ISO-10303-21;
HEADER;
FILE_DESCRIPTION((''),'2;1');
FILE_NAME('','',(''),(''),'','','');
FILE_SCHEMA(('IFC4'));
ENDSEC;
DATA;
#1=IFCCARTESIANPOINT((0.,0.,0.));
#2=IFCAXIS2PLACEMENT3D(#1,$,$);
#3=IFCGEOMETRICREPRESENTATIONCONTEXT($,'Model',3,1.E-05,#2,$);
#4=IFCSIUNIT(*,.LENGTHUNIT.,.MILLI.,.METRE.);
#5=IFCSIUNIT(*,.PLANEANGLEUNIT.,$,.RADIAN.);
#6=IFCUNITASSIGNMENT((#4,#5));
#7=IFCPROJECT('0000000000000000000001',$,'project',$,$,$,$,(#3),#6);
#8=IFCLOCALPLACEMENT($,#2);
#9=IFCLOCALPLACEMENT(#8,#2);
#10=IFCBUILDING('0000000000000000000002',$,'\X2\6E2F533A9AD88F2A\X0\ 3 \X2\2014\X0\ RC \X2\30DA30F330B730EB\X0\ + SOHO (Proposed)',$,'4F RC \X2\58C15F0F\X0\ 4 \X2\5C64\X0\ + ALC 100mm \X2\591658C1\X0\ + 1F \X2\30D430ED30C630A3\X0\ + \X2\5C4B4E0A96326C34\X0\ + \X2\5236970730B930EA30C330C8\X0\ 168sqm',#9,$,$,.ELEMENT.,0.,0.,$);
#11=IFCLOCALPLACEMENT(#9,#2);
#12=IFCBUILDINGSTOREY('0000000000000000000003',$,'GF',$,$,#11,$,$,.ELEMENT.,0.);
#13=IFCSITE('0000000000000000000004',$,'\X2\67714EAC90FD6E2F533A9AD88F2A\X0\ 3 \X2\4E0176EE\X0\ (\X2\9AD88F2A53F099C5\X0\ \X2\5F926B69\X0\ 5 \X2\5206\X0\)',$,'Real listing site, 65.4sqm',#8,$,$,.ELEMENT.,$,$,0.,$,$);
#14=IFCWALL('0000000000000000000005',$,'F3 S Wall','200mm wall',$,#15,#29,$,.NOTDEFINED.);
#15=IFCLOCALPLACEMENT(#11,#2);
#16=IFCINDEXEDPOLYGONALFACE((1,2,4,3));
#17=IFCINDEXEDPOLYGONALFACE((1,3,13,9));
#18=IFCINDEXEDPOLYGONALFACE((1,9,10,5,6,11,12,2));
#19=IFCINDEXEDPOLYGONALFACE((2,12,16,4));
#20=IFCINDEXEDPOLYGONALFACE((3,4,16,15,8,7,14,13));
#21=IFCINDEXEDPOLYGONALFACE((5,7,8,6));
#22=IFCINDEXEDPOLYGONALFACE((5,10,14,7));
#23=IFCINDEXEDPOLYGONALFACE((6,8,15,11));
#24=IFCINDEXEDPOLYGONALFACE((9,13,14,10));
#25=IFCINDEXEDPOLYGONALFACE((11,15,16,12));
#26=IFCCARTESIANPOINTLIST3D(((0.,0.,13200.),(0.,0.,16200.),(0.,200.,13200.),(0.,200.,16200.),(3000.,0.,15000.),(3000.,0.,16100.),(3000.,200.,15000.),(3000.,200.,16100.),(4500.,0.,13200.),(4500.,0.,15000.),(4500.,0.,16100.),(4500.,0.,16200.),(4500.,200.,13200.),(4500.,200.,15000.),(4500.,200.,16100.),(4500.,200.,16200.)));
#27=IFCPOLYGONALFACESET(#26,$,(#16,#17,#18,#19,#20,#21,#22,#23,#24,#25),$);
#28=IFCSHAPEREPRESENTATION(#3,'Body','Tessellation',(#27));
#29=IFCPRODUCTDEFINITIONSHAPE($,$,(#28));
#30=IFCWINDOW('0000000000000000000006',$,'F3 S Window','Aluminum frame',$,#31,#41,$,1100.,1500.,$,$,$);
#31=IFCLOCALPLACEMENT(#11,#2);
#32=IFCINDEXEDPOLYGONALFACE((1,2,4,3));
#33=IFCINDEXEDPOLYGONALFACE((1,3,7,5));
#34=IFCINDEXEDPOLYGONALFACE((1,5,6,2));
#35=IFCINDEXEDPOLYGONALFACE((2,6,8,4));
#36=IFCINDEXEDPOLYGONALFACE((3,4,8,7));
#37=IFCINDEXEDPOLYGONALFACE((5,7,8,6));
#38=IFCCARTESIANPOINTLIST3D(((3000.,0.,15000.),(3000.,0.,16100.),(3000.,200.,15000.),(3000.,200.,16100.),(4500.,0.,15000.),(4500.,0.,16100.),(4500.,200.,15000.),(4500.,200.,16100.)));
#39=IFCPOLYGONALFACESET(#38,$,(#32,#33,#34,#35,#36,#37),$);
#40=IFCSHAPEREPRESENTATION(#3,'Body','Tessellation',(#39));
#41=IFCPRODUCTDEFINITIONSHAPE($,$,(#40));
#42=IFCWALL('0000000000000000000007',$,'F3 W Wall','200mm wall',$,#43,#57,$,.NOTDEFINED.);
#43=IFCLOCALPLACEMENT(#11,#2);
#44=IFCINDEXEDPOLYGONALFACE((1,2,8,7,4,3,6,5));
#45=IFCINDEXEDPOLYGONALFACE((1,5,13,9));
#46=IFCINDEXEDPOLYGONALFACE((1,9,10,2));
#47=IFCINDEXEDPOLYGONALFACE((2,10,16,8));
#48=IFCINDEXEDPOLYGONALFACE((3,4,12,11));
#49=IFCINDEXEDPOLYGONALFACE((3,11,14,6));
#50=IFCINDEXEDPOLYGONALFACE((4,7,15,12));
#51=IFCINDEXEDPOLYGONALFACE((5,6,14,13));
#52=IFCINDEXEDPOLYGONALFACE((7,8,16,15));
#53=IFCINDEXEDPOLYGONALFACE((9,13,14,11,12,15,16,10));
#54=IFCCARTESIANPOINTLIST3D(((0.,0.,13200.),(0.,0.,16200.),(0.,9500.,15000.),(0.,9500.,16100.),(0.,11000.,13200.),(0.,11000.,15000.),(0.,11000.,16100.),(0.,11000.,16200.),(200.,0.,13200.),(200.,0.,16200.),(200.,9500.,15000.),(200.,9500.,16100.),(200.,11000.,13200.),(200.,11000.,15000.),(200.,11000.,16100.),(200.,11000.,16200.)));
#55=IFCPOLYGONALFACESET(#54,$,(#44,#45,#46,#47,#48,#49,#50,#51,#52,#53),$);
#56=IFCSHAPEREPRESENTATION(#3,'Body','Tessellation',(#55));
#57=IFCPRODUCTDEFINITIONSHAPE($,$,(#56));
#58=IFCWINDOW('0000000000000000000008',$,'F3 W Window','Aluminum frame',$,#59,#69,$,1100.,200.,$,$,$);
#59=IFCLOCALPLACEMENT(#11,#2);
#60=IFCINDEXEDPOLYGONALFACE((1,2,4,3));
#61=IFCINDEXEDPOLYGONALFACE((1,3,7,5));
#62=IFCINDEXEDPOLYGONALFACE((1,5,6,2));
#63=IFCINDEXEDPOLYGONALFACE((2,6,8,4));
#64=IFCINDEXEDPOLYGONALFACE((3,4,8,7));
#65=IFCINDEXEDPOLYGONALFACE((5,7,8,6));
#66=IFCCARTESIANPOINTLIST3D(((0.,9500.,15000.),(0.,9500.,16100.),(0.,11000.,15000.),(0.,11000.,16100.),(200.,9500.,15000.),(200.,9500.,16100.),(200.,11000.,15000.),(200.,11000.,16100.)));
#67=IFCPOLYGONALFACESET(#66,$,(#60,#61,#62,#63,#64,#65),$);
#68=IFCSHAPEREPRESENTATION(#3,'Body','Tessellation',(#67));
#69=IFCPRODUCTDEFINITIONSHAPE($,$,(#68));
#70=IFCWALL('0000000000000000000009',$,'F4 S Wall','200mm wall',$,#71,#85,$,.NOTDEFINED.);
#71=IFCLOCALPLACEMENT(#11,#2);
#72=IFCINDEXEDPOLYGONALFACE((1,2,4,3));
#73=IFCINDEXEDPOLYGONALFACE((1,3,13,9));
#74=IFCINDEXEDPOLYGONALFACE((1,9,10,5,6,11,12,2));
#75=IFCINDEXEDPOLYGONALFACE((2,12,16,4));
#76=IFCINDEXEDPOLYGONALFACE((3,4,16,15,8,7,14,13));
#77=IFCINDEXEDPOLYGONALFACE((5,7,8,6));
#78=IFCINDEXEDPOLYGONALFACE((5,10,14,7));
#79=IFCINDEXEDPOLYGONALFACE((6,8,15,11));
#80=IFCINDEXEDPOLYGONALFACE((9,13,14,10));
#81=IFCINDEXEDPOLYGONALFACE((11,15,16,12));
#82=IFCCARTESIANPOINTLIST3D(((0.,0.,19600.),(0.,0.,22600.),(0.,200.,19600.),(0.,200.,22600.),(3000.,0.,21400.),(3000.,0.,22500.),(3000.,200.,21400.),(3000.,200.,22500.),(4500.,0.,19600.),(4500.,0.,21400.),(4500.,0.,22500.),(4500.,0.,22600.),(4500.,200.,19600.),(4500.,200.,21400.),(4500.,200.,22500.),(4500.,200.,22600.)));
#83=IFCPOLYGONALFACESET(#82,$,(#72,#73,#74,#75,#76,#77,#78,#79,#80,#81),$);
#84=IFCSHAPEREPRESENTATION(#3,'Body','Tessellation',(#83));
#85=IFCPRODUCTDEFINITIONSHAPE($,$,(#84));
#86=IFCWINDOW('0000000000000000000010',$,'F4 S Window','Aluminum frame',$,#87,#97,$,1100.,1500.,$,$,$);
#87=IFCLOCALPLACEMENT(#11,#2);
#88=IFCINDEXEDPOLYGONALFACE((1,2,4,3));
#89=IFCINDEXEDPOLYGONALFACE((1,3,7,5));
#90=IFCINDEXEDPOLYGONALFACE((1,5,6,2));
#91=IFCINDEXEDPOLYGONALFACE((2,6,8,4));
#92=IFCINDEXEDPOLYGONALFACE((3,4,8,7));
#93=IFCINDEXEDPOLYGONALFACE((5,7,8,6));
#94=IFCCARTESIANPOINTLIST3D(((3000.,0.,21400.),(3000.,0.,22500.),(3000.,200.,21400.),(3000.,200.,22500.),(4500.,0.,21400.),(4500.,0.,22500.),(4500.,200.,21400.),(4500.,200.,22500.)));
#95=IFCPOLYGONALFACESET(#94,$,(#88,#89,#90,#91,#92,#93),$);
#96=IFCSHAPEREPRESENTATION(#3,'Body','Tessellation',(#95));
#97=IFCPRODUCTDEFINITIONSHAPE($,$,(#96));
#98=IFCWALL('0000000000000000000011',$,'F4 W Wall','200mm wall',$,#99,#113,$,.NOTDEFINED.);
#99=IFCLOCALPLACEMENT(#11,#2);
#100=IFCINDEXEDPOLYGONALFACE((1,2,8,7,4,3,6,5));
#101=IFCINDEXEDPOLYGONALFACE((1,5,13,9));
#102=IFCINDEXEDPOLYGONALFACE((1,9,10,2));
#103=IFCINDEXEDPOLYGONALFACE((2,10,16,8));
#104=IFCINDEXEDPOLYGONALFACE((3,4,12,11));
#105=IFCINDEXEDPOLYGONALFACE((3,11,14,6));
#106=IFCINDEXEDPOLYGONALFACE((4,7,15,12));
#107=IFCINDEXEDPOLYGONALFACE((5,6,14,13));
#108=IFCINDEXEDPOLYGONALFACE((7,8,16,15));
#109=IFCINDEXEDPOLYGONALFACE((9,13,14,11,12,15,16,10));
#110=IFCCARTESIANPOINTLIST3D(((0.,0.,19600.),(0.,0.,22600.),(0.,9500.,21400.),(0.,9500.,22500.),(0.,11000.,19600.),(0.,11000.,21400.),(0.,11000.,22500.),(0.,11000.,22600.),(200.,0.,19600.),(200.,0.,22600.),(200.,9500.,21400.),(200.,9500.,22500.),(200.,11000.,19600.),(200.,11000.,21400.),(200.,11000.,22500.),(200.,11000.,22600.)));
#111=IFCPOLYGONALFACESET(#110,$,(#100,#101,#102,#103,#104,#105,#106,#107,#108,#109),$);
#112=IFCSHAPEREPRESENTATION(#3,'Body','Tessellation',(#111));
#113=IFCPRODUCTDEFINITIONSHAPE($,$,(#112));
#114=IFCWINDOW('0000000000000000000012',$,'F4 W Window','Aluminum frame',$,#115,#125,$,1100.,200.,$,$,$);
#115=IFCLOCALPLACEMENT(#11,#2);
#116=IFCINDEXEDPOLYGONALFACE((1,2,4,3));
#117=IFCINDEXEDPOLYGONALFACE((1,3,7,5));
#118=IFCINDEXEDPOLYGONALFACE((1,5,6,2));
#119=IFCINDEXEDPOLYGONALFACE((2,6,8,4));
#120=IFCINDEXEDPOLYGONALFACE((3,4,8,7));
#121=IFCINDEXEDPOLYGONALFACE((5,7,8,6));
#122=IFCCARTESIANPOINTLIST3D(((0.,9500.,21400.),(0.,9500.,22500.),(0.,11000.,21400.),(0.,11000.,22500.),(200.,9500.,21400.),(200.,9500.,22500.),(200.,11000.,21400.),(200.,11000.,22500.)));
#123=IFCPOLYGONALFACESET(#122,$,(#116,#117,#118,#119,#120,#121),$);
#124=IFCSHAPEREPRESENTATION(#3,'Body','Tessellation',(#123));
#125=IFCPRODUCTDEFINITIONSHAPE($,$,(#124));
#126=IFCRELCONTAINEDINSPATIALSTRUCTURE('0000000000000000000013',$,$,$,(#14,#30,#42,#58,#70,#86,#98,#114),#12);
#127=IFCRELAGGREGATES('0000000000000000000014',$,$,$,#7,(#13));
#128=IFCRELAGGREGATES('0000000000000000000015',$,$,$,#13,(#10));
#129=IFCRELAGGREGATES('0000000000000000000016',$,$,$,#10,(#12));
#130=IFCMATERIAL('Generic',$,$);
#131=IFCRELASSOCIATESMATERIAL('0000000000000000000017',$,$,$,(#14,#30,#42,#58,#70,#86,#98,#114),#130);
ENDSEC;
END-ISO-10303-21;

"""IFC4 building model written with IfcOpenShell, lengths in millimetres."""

from ifc_helpers import new_model, si_unit, frame, frame_2d, origin, place, context, project, spatial, rectangle, extrude, material, element, fill, save


model = new_model("IFC4")

# Units and contexts
model_context = context("Model", 3, precision=1e-05, world=origin())
ifc_project = project(units=[si_unit("LENGTHUNIT", "METRE", prefix="MILLI"), si_unit("PLANEANGLEUNIT", "RADIAN")], contexts=[model_context])

# Site, building, storey
site_placement = place(None, origin())
site = spatial("IfcSite", under=ifc_project, at=site_placement, Name="東京都港区高輪 3 丁目 (高輪台駅 徒歩 5 分)", ObjectType="Real listing site, 65.4sqm", CompositionType="ELEMENT", RefElevation=0.0)
building_placement = place(site_placement, origin())
building = spatial("IfcBuilding", under=site, at=building_placement, Name="港区高輪 3 — RC ペンシル + SOHO (Proposed)", ObjectType="4F RC 壁式 4 層 + ALC 100mm 外壁 + 1F ピロティ + 屋上防水 + 制震スリット 168sqm", CompositionType="ELEMENT", ElevationOfRefHeight=0.0, ElevationOfTerrain=0.0)
storey_placement = place(building_placement, origin())
storey = spatial("IfcBuildingStorey", under=building, at=storey_placement, Name="GF", CompositionType="ELEMENT", Elevation=0.0)

# Walls, openings, windows
ifc_material_1 = material(Name="Generic")
wall_1_placement = place(storey_placement, frame((0.0, 0.0, 6600.0)))
wall_1 = element("IfcWall", 1, at=wall_1_placement, inside=storey, material=ifc_material_1, Name="F3 S Wall", Description="200mm wall", PredefinedType="NOTDEFINED", context=model_context, shape_type="SweptSolid", body=[
    extrude(rectangle(XDim=4500.0, YDim=200.0, at=frame_2d((2250.0, 100.0))), frame((0.0, 0.0, 6600.0)), (0.0, 0.0, 1.0), 3000.0),
])
opening_1_placement = place(storey_placement, frame((1500.0, 0.0, 7500.0)))
opening_1 = element("IfcOpeningElement", 2, at=opening_1_placement, cuts=wall_1, PredefinedType="NOTDEFINED", context=model_context, shape_type="SweptSolid", body=[
    extrude(rectangle(XDim=1500.0, YDim=200.0, at=frame_2d((750.0, 100.0))), frame((1500.0, 0.0, 7500.0)), (0.0, 0.0, 1.0), 1100.0),
])
window_1_placement = place(storey_placement, frame((1500.0, 0.0, 7500.0)))
window_1 = element("IfcWindow", 3, at=window_1_placement, inside=storey, material=ifc_material_1, Name="F3 S Window", Description="Aluminum frame", OverallHeight=1100.0, OverallWidth=1500.0, context=model_context, shape_type="SweptSolid", body=[
    extrude(rectangle(XDim=1500.0, YDim=200.0, at=frame_2d((750.0, 100.0))), frame((1500.0, 0.0, 7500.0)), (0.0, 0.0, 1.0), 1100.0),
])
fill(opening_1, window_1)
wall_2_placement = place(storey_placement, frame((0.0, 0.0, 6600.0)))
wall_2 = element("IfcWall", 4, at=wall_2_placement, inside=storey, material=ifc_material_1, Name="F3 W Wall", Description="200mm wall", PredefinedType="NOTDEFINED", context=model_context, shape_type="SweptSolid", body=[
    extrude(rectangle(XDim=200.0, YDim=11000.0, at=frame_2d((100.0, 5500.0))), frame((0.0, 0.0, 6600.0)), (0.0, 0.0, 1.0), 3000.0),
])
opening_2_placement = place(storey_placement, frame((0.0, 4750.0, 7500.0)))
opening_2 = element("IfcOpeningElement", 5, at=opening_2_placement, cuts=wall_2, PredefinedType="NOTDEFINED", context=model_context, shape_type="SweptSolid", body=[
    extrude(rectangle(XDim=200.0, YDim=1500.0, at=frame_2d((100.0, 750.0))), frame((0.0, 4750.0, 7500.0)), (0.0, 0.0, 1.0), 1100.0),
])
window_2_placement = place(storey_placement, frame((0.0, 4750.0, 7500.0)))
window_2 = element("IfcWindow", 6, at=window_2_placement, inside=storey, material=ifc_material_1, Name="F3 W Window", Description="Aluminum frame", OverallHeight=1100.0, OverallWidth=200.0, context=model_context, shape_type="SweptSolid", body=[
    extrude(rectangle(XDim=200.0, YDim=1500.0, at=frame_2d((100.0, 750.0))), frame((0.0, 4750.0, 7500.0)), (0.0, 0.0, 1.0), 1100.0),
])
fill(opening_2, window_2)
wall_3_placement = place(storey_placement, frame((0.0, 0.0, 9800.0)))
wall_3 = element("IfcWall", 7, at=wall_3_placement, inside=storey, material=ifc_material_1, Name="F4 S Wall", Description="200mm wall", PredefinedType="NOTDEFINED", context=model_context, shape_type="SweptSolid", body=[
    extrude(rectangle(XDim=4500.0, YDim=200.0, at=frame_2d((2250.0, 100.0))), frame((0.0, 0.0, 9800.0)), (0.0, 0.0, 1.0), 3000.0),
])
opening_3_placement = place(storey_placement, frame((1500.0, 0.0, 10700.0)))
opening_3 = element("IfcOpeningElement", 8, at=opening_3_placement, cuts=wall_3, PredefinedType="NOTDEFINED", context=model_context, shape_type="SweptSolid", body=[
    extrude(rectangle(XDim=1500.0, YDim=200.0, at=frame_2d((750.0, 100.0))), frame((1500.0, 0.0, 10700.0)), (0.0, 0.0, 1.0), 1100.0),
])
window_3_placement = place(storey_placement, frame((1500.0, 0.0, 10700.0)))
window_3 = element("IfcWindow", 9, at=window_3_placement, inside=storey, material=ifc_material_1, Name="F4 S Window", Description="Aluminum frame", OverallHeight=1100.0, OverallWidth=1500.0, context=model_context, shape_type="SweptSolid", body=[
    extrude(rectangle(XDim=1500.0, YDim=200.0, at=frame_2d((750.0, 100.0))), frame((1500.0, 0.0, 10700.0)), (0.0, 0.0, 1.0), 1100.0),
])
fill(opening_3, window_3)
wall_4_placement = place(storey_placement, frame((0.0, 0.0, 9800.0)))
wall_4 = element("IfcWall", 10, at=wall_4_placement, inside=storey, material=ifc_material_1, Name="F4 W Wall", Description="200mm wall", PredefinedType="NOTDEFINED", context=model_context, shape_type="SweptSolid", body=[
    extrude(rectangle(XDim=200.0, YDim=11000.0, at=frame_2d((100.0, 5500.0))), frame((0.0, 0.0, 9800.0)), (0.0, 0.0, 1.0), 3000.0),
])
opening_4_placement = place(storey_placement, frame((0.0, 4750.0, 10700.0)))
opening_4 = element("IfcOpeningElement", 11, at=opening_4_placement, cuts=wall_4, PredefinedType="NOTDEFINED", context=model_context, shape_type="SweptSolid", body=[
    extrude(rectangle(XDim=200.0, YDim=1500.0, at=frame_2d((100.0, 750.0))), frame((0.0, 4750.0, 10700.0)), (0.0, 0.0, 1.0), 1100.0),
])
window_4_placement = place(storey_placement, frame((0.0, 4750.0, 10700.0)))
window_4 = element("IfcWindow", 12, at=window_4_placement, inside=storey, material=ifc_material_1, Name="F4 W Window", Description="Aluminum frame", OverallHeight=1100.0, OverallWidth=200.0, context=model_context, shape_type="SweptSolid", body=[
    extrude(rectangle(XDim=200.0, YDim=1500.0, at=frame_2d((100.0, 750.0))), frame((0.0, 4750.0, 10700.0)), (0.0, 0.0, 1.0), 1100.0),
])
fill(opening_4, window_4)

save(model, "model.ifc")
